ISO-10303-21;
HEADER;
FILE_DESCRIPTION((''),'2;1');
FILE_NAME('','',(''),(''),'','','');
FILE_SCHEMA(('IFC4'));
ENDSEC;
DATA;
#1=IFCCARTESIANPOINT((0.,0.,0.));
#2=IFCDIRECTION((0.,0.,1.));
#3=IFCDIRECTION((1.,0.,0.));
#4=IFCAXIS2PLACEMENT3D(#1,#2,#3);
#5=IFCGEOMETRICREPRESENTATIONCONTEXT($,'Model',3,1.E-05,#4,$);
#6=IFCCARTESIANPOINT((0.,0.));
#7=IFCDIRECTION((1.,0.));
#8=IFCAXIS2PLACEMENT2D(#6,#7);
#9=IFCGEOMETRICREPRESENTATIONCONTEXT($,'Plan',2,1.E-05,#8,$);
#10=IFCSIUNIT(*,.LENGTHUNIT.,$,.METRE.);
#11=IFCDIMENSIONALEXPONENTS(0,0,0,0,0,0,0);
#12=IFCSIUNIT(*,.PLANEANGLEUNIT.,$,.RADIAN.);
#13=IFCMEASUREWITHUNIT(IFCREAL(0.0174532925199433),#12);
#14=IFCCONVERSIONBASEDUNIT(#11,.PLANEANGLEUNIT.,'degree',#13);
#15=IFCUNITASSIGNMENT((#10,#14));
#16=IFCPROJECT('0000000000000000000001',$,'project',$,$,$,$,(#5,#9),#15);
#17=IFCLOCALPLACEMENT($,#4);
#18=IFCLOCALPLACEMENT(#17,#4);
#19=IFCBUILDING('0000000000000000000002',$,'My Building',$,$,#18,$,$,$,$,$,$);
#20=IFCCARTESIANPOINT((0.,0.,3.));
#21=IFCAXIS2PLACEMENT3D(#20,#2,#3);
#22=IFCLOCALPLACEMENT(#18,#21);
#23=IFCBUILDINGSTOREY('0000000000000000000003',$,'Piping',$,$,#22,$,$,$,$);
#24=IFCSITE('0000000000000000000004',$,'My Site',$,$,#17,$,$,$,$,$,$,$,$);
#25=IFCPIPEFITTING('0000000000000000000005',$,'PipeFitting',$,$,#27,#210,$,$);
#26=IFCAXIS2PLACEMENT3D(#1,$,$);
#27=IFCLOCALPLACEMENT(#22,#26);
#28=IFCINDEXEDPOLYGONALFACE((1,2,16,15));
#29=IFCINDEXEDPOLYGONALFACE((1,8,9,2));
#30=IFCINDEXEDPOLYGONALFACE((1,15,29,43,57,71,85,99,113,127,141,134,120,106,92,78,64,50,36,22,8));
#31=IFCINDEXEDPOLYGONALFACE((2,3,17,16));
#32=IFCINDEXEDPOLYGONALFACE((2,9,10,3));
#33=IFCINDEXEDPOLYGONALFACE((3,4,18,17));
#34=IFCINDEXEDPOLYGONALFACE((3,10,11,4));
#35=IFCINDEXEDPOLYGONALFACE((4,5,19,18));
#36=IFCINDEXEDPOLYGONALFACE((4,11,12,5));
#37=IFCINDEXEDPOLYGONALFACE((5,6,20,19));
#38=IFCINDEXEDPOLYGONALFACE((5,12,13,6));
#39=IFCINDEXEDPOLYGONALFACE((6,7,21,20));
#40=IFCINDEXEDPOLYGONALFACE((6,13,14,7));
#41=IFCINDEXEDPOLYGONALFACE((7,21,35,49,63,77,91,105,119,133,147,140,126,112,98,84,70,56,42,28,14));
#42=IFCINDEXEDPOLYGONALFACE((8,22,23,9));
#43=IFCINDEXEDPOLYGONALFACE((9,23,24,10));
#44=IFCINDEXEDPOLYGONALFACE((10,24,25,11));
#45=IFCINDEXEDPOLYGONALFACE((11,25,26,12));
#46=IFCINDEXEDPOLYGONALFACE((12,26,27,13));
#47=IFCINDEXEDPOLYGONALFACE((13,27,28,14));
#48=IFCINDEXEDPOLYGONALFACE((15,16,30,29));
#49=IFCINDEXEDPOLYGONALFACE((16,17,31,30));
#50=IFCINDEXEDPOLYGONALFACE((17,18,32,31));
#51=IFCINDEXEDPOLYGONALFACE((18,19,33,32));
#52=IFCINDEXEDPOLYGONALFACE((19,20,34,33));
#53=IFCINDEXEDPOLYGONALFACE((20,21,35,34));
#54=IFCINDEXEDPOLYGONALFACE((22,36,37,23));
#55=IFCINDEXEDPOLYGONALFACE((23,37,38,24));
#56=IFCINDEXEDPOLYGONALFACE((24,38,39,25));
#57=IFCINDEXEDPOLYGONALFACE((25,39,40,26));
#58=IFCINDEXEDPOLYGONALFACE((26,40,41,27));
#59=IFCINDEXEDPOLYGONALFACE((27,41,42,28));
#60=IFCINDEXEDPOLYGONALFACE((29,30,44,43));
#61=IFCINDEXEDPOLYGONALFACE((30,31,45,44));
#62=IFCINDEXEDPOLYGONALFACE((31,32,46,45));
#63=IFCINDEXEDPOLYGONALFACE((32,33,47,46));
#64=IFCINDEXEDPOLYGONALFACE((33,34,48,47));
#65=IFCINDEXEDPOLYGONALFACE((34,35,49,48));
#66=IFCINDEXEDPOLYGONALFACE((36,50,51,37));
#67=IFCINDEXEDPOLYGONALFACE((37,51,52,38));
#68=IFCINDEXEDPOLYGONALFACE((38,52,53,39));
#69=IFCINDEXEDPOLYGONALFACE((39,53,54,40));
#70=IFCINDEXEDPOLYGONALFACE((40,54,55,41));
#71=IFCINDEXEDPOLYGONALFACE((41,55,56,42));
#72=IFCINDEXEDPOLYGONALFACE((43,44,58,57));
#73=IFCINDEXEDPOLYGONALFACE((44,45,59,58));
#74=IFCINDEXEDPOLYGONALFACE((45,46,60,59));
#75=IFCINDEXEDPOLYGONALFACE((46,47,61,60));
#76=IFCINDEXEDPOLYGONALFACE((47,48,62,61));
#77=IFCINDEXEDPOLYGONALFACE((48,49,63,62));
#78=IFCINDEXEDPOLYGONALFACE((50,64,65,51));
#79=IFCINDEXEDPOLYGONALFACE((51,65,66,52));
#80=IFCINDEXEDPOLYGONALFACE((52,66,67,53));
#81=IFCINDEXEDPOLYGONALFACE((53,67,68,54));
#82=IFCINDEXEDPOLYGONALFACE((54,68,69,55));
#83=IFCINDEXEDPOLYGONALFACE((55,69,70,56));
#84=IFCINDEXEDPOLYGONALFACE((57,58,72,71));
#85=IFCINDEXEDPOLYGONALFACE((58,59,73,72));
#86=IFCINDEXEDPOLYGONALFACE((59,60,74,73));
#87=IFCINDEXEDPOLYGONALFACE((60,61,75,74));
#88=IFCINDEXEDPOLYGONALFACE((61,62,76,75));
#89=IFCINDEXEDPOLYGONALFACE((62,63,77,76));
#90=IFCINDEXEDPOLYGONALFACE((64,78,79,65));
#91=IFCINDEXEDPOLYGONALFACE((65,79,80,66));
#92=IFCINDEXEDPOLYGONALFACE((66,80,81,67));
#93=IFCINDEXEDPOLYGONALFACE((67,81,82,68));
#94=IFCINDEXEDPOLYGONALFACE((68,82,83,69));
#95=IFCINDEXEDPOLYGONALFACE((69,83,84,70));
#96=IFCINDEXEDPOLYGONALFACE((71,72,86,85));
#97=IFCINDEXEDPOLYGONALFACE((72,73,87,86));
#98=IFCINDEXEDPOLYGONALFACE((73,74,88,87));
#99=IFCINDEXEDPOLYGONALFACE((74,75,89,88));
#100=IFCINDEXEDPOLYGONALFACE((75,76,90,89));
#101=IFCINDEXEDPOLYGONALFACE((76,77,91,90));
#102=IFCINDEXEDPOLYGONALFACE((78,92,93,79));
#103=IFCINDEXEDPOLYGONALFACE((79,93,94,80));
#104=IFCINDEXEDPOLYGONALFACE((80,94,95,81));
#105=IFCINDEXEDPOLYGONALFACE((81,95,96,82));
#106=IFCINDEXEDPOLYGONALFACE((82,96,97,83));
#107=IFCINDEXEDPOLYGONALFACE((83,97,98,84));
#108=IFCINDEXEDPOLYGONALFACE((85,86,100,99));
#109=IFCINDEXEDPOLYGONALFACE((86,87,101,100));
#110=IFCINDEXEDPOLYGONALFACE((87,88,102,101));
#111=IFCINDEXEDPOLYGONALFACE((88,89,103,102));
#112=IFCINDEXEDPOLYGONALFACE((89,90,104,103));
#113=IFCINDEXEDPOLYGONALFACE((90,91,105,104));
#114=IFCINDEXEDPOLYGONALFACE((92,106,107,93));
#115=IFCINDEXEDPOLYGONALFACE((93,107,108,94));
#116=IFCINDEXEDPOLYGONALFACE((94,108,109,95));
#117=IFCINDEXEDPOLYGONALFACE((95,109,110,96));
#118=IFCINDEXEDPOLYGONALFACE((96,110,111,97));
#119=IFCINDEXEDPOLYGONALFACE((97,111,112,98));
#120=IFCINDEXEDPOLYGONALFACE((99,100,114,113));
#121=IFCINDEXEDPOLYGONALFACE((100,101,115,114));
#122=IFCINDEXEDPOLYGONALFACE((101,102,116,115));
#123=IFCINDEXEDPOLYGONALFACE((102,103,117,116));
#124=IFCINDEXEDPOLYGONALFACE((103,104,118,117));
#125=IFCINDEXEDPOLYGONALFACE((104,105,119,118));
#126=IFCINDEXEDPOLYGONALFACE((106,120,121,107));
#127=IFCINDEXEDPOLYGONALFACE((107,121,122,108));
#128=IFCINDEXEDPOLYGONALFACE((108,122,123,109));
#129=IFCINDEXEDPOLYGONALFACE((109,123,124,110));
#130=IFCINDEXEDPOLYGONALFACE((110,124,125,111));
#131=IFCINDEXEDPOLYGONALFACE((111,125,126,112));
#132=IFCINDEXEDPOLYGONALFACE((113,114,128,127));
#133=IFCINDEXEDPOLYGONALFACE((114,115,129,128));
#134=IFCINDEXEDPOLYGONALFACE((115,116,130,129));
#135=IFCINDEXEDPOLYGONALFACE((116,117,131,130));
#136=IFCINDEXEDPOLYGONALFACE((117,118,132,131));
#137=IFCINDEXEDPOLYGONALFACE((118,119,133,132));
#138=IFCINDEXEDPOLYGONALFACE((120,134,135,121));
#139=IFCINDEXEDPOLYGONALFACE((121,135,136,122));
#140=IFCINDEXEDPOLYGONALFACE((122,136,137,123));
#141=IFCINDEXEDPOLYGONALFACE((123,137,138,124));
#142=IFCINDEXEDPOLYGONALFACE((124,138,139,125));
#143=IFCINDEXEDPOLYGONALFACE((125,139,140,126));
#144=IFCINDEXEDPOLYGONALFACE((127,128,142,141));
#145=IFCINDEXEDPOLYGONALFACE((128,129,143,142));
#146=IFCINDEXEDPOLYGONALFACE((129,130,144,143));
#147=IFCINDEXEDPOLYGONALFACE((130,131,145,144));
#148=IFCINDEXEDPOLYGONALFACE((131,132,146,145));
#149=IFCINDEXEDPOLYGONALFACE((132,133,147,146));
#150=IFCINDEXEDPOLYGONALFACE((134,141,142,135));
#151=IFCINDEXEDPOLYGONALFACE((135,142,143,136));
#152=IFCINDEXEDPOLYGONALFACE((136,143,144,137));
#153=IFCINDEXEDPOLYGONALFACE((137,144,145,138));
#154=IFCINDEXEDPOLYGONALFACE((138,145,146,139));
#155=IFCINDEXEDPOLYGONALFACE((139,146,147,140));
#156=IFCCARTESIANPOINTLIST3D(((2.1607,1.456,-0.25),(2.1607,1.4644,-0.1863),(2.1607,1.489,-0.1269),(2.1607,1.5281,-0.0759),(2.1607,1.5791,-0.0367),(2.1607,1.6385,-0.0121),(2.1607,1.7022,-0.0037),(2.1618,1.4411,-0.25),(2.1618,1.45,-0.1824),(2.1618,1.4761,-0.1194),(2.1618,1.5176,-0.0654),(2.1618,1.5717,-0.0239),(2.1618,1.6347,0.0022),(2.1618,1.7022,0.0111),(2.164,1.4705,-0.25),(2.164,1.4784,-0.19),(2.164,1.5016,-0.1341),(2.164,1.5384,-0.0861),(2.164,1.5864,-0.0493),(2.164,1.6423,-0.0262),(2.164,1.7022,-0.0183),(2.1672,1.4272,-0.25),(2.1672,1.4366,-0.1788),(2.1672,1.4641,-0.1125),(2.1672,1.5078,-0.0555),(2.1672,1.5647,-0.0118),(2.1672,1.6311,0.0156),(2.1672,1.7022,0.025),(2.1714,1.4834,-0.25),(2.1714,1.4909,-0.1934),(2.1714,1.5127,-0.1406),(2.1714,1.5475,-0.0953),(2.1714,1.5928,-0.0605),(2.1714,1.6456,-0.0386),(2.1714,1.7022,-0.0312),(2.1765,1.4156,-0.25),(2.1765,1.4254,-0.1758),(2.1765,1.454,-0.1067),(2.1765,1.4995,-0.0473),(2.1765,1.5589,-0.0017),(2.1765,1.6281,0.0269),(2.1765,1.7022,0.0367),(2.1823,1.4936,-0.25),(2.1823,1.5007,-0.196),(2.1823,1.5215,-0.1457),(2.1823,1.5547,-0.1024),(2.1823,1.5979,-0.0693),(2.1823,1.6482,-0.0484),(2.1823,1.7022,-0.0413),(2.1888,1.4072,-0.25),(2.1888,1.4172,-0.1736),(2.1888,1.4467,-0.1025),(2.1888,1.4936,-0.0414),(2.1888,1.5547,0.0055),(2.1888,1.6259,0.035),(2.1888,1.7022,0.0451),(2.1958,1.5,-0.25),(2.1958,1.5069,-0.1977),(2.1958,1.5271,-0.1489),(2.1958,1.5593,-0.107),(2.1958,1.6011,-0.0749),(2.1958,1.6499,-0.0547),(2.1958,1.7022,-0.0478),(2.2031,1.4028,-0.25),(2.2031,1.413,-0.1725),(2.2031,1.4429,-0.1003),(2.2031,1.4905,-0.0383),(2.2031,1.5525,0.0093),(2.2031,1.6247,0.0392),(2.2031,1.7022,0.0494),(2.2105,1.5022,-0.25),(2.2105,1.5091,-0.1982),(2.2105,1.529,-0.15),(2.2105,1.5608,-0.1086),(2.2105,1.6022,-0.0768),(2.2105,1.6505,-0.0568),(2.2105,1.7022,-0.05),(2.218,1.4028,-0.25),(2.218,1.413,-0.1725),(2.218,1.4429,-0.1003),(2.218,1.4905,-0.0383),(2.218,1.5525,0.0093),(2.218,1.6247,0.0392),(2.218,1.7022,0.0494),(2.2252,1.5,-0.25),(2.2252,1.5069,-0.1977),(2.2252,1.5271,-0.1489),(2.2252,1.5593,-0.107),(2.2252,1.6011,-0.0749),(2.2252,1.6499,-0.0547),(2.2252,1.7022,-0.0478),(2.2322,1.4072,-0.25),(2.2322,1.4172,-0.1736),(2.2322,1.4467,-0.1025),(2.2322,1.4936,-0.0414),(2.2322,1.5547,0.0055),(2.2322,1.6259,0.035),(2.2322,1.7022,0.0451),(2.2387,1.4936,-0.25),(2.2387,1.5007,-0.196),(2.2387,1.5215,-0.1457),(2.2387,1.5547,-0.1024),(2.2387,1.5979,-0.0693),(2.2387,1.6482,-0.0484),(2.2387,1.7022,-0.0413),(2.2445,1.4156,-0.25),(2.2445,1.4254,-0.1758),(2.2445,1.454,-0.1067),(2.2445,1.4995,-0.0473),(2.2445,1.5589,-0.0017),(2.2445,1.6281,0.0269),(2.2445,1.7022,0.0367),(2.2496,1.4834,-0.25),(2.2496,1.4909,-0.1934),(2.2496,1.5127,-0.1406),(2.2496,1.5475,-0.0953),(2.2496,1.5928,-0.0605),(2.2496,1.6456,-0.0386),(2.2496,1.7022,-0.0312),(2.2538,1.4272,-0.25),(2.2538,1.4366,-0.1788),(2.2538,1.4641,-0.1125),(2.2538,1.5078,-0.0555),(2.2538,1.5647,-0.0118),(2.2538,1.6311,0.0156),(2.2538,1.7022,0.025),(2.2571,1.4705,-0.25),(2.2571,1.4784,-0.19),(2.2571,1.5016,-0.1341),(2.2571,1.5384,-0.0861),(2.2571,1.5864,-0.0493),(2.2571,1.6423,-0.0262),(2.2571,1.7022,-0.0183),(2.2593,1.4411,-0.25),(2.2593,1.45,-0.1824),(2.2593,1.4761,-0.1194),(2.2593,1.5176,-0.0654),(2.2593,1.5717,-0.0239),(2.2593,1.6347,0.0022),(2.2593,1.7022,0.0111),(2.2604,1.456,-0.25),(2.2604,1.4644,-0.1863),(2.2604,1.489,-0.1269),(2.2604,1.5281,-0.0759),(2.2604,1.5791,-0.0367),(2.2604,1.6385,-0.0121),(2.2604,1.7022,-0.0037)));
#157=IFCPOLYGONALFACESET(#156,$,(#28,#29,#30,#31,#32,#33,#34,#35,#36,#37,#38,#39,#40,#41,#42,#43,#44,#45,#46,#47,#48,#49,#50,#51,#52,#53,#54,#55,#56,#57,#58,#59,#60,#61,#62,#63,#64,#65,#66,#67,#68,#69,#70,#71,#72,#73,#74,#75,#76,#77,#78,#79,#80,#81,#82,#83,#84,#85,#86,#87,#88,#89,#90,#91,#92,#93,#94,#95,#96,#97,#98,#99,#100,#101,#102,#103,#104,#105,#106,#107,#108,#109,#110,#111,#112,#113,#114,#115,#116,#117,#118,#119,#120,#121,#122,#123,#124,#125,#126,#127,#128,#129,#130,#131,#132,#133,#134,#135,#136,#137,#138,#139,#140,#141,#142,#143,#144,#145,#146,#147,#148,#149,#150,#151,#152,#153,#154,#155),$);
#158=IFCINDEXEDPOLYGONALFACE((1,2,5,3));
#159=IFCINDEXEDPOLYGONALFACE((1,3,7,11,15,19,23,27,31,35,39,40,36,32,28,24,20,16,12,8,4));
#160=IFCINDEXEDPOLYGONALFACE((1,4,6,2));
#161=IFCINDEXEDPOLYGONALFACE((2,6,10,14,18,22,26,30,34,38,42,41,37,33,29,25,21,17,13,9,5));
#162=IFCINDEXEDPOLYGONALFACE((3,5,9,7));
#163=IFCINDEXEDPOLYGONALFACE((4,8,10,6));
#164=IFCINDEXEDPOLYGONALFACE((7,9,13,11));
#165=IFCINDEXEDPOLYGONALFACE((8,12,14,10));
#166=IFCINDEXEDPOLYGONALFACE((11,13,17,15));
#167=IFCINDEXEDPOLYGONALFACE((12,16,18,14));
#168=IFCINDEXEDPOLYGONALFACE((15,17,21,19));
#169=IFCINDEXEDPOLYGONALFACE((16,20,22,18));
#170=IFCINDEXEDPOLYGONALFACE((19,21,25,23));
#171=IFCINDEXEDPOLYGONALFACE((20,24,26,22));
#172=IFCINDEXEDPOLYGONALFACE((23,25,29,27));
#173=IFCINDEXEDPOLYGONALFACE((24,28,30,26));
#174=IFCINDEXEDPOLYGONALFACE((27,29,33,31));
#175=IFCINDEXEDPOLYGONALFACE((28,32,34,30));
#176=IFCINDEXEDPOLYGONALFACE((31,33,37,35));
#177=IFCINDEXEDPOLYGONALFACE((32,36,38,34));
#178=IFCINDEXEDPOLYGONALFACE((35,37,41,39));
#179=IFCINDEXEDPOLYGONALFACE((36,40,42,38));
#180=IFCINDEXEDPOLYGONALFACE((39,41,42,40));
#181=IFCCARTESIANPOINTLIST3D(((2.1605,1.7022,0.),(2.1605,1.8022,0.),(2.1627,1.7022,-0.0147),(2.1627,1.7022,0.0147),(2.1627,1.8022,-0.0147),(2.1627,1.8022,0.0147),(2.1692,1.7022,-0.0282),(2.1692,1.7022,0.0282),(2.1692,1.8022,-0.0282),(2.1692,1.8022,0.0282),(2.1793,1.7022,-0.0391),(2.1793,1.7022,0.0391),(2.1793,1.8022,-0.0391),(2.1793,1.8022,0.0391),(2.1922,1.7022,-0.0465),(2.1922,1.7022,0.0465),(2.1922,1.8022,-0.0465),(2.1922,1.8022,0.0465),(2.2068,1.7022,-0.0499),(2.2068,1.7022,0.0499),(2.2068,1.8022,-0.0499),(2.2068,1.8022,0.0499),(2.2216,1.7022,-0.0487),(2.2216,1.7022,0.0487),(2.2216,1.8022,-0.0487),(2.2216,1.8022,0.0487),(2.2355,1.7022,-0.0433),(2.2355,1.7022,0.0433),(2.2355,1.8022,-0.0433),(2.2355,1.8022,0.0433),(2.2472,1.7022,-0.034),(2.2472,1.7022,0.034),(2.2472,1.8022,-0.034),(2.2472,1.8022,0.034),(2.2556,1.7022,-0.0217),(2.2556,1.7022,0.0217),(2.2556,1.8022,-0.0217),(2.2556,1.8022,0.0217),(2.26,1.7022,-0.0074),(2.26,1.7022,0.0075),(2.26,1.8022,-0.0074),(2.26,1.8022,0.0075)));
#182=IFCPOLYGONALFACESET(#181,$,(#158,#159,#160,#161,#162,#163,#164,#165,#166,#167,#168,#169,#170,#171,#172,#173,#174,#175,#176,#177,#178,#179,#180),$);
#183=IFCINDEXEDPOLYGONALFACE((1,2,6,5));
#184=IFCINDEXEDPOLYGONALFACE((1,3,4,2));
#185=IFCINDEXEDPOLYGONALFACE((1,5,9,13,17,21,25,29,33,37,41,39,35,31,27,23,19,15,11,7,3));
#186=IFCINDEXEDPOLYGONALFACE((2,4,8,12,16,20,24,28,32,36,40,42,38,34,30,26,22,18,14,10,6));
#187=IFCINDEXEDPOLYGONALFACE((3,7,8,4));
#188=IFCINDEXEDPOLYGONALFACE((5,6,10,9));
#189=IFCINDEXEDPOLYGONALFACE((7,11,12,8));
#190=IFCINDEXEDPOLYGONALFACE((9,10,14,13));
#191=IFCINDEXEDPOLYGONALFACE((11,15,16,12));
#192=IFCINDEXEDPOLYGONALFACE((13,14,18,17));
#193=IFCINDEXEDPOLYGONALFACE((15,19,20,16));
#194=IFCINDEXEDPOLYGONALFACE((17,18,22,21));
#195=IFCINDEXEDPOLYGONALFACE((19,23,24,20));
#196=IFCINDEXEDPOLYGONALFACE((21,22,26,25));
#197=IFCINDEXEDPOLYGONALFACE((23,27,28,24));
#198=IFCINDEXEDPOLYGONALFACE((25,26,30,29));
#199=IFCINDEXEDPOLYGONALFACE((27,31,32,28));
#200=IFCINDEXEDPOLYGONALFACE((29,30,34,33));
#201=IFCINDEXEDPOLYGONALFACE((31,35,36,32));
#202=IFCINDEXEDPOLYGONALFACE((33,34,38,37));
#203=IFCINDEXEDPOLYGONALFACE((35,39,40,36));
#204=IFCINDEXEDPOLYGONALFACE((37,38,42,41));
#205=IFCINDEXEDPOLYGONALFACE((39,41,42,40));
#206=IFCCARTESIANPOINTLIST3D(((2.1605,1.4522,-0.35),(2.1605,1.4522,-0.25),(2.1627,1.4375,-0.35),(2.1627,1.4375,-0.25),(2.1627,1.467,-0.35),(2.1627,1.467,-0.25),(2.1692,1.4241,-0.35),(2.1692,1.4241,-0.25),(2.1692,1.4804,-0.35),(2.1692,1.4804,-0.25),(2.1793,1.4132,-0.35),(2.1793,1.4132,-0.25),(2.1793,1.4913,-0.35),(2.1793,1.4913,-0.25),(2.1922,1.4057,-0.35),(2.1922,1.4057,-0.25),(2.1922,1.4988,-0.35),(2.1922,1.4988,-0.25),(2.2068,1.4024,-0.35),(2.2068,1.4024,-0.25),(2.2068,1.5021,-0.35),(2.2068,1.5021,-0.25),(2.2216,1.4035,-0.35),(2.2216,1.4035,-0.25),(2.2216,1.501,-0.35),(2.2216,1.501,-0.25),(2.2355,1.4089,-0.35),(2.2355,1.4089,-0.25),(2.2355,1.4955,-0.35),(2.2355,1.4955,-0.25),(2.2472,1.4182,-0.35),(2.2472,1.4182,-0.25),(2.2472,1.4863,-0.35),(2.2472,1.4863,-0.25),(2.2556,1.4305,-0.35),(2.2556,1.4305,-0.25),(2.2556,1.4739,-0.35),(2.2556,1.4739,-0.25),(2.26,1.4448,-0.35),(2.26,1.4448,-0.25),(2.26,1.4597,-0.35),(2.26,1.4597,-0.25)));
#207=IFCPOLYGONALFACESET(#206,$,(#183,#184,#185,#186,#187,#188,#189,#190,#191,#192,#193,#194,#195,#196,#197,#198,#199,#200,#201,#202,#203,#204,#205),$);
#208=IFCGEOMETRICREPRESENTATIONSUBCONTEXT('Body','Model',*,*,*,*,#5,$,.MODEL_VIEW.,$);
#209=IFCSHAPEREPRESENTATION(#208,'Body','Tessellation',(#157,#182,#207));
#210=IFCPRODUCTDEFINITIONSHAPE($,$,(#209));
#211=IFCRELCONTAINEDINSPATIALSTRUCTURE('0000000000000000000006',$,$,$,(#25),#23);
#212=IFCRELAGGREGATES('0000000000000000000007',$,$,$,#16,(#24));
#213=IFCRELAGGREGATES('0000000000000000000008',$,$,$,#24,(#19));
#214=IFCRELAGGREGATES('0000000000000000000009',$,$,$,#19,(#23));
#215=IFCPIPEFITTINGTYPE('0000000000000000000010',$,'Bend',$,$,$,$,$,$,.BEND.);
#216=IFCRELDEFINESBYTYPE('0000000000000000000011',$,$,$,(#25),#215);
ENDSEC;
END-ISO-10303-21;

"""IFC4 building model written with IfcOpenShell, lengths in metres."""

from ifc_helpers import new_model, entity, si_unit, converted_unit, frame, origin_with_axes, origin_2d_with_axis, place, context, subcontext, project, spatial, circle, extrude, source, transform, mapped, type_object, type_shapes, element, save


model = new_model("IFC4")

# Units and contexts
model_context = context("Model", 3, precision=1e-05, world=origin_with_axes())
plan_context = context("Plan", 2, precision=1e-05, world=origin_2d_with_axis())
body_context = subcontext(model_context, "Body", "Model", "MODEL_VIEW")
ifc_project = project(units=[si_unit("LENGTHUNIT", "METRE"), converted_unit("PLANEANGLEUNIT", "degree", entity("IfcReal", 0.0174532925199433), si_unit("PLANEANGLEUNIT", "RADIAN"), dimensions=[0, 0, 0, 0, 0, 0, 0])], contexts=[model_context, plan_context])

# Site, building, storey
site_placement = place(None, origin_with_axes())
site = spatial("IfcSite", under=ifc_project, at=site_placement, Name="My Site")
building_placement = place(site_placement, origin_with_axes())
building = spatial("IfcBuilding", under=site, at=building_placement, Name="My Building")
storey_placement = place(building_placement, frame((0.0, 0.0, 3.0), z_axis=(0.0, 0.0, 1.0), x_axis=(1.0, 0.0, 0.0)))
storey = spatial("IfcBuildingStorey", under=building, at=storey_placement, Name="Piping")

# Pipe fitting
pipe_fitting_type = type_object("IfcPipeFittingType", Name="Bend", PredefinedType="BEND")
shared_shape = source(origin_with_axes(), body_context, "Body", "SolidModel", [
    entity("IfcSweptDiskSolid", entity("IfcIndexedPolyCurve", entity("IfcCartesianPointList3D", [[0.0, 0.0, -0.1], [0.0, -0.0732, -0.2768], [0.0, -0.25, -0.35]]), [entity("IfcArcIndex", [1, 2, 3])]), 0.05),
    extrude(circle(Radius=0.05), origin_with_axes(), (0.0, 0.0, -1.0), 0.1),
    extrude(circle(Radius=0.05), frame((0.0, -0.25, -0.35), z_axis=(0.0, -1.0, 0.0), x_axis=(1.0, 0.0, 0.0)), (0.0, 0.0, 1.0), 0.1),
])
type_shapes(pipe_fitting_type, [shared_shape])
for number, where, z_axis, x_axis, name in (
    (1, (2.2105, 1.8022, 0.0), (0.0, 1.0, 0.0), (-1.0, 0.0, 0.0), "PipeFitting"),
):
    element("IfcPipeFitting", number, at=place(storey_placement, frame(where, z_axis=z_axis, x_axis=x_axis)), inside=storey, type_object=pipe_fitting_type, Name=name, context=body_context, shape_type="MappedRepresentation", body=[
        mapped(shared_shape, transform((0.0, 0.0, 0.0), x_axis=(1.0, 0.0, 0.0), y_axis=(0.0, 1.0, 0.0), z_axis=(0.0, 0.0, 1.0), scale=1.0)),
    ])

save(model, "model.ifc")
